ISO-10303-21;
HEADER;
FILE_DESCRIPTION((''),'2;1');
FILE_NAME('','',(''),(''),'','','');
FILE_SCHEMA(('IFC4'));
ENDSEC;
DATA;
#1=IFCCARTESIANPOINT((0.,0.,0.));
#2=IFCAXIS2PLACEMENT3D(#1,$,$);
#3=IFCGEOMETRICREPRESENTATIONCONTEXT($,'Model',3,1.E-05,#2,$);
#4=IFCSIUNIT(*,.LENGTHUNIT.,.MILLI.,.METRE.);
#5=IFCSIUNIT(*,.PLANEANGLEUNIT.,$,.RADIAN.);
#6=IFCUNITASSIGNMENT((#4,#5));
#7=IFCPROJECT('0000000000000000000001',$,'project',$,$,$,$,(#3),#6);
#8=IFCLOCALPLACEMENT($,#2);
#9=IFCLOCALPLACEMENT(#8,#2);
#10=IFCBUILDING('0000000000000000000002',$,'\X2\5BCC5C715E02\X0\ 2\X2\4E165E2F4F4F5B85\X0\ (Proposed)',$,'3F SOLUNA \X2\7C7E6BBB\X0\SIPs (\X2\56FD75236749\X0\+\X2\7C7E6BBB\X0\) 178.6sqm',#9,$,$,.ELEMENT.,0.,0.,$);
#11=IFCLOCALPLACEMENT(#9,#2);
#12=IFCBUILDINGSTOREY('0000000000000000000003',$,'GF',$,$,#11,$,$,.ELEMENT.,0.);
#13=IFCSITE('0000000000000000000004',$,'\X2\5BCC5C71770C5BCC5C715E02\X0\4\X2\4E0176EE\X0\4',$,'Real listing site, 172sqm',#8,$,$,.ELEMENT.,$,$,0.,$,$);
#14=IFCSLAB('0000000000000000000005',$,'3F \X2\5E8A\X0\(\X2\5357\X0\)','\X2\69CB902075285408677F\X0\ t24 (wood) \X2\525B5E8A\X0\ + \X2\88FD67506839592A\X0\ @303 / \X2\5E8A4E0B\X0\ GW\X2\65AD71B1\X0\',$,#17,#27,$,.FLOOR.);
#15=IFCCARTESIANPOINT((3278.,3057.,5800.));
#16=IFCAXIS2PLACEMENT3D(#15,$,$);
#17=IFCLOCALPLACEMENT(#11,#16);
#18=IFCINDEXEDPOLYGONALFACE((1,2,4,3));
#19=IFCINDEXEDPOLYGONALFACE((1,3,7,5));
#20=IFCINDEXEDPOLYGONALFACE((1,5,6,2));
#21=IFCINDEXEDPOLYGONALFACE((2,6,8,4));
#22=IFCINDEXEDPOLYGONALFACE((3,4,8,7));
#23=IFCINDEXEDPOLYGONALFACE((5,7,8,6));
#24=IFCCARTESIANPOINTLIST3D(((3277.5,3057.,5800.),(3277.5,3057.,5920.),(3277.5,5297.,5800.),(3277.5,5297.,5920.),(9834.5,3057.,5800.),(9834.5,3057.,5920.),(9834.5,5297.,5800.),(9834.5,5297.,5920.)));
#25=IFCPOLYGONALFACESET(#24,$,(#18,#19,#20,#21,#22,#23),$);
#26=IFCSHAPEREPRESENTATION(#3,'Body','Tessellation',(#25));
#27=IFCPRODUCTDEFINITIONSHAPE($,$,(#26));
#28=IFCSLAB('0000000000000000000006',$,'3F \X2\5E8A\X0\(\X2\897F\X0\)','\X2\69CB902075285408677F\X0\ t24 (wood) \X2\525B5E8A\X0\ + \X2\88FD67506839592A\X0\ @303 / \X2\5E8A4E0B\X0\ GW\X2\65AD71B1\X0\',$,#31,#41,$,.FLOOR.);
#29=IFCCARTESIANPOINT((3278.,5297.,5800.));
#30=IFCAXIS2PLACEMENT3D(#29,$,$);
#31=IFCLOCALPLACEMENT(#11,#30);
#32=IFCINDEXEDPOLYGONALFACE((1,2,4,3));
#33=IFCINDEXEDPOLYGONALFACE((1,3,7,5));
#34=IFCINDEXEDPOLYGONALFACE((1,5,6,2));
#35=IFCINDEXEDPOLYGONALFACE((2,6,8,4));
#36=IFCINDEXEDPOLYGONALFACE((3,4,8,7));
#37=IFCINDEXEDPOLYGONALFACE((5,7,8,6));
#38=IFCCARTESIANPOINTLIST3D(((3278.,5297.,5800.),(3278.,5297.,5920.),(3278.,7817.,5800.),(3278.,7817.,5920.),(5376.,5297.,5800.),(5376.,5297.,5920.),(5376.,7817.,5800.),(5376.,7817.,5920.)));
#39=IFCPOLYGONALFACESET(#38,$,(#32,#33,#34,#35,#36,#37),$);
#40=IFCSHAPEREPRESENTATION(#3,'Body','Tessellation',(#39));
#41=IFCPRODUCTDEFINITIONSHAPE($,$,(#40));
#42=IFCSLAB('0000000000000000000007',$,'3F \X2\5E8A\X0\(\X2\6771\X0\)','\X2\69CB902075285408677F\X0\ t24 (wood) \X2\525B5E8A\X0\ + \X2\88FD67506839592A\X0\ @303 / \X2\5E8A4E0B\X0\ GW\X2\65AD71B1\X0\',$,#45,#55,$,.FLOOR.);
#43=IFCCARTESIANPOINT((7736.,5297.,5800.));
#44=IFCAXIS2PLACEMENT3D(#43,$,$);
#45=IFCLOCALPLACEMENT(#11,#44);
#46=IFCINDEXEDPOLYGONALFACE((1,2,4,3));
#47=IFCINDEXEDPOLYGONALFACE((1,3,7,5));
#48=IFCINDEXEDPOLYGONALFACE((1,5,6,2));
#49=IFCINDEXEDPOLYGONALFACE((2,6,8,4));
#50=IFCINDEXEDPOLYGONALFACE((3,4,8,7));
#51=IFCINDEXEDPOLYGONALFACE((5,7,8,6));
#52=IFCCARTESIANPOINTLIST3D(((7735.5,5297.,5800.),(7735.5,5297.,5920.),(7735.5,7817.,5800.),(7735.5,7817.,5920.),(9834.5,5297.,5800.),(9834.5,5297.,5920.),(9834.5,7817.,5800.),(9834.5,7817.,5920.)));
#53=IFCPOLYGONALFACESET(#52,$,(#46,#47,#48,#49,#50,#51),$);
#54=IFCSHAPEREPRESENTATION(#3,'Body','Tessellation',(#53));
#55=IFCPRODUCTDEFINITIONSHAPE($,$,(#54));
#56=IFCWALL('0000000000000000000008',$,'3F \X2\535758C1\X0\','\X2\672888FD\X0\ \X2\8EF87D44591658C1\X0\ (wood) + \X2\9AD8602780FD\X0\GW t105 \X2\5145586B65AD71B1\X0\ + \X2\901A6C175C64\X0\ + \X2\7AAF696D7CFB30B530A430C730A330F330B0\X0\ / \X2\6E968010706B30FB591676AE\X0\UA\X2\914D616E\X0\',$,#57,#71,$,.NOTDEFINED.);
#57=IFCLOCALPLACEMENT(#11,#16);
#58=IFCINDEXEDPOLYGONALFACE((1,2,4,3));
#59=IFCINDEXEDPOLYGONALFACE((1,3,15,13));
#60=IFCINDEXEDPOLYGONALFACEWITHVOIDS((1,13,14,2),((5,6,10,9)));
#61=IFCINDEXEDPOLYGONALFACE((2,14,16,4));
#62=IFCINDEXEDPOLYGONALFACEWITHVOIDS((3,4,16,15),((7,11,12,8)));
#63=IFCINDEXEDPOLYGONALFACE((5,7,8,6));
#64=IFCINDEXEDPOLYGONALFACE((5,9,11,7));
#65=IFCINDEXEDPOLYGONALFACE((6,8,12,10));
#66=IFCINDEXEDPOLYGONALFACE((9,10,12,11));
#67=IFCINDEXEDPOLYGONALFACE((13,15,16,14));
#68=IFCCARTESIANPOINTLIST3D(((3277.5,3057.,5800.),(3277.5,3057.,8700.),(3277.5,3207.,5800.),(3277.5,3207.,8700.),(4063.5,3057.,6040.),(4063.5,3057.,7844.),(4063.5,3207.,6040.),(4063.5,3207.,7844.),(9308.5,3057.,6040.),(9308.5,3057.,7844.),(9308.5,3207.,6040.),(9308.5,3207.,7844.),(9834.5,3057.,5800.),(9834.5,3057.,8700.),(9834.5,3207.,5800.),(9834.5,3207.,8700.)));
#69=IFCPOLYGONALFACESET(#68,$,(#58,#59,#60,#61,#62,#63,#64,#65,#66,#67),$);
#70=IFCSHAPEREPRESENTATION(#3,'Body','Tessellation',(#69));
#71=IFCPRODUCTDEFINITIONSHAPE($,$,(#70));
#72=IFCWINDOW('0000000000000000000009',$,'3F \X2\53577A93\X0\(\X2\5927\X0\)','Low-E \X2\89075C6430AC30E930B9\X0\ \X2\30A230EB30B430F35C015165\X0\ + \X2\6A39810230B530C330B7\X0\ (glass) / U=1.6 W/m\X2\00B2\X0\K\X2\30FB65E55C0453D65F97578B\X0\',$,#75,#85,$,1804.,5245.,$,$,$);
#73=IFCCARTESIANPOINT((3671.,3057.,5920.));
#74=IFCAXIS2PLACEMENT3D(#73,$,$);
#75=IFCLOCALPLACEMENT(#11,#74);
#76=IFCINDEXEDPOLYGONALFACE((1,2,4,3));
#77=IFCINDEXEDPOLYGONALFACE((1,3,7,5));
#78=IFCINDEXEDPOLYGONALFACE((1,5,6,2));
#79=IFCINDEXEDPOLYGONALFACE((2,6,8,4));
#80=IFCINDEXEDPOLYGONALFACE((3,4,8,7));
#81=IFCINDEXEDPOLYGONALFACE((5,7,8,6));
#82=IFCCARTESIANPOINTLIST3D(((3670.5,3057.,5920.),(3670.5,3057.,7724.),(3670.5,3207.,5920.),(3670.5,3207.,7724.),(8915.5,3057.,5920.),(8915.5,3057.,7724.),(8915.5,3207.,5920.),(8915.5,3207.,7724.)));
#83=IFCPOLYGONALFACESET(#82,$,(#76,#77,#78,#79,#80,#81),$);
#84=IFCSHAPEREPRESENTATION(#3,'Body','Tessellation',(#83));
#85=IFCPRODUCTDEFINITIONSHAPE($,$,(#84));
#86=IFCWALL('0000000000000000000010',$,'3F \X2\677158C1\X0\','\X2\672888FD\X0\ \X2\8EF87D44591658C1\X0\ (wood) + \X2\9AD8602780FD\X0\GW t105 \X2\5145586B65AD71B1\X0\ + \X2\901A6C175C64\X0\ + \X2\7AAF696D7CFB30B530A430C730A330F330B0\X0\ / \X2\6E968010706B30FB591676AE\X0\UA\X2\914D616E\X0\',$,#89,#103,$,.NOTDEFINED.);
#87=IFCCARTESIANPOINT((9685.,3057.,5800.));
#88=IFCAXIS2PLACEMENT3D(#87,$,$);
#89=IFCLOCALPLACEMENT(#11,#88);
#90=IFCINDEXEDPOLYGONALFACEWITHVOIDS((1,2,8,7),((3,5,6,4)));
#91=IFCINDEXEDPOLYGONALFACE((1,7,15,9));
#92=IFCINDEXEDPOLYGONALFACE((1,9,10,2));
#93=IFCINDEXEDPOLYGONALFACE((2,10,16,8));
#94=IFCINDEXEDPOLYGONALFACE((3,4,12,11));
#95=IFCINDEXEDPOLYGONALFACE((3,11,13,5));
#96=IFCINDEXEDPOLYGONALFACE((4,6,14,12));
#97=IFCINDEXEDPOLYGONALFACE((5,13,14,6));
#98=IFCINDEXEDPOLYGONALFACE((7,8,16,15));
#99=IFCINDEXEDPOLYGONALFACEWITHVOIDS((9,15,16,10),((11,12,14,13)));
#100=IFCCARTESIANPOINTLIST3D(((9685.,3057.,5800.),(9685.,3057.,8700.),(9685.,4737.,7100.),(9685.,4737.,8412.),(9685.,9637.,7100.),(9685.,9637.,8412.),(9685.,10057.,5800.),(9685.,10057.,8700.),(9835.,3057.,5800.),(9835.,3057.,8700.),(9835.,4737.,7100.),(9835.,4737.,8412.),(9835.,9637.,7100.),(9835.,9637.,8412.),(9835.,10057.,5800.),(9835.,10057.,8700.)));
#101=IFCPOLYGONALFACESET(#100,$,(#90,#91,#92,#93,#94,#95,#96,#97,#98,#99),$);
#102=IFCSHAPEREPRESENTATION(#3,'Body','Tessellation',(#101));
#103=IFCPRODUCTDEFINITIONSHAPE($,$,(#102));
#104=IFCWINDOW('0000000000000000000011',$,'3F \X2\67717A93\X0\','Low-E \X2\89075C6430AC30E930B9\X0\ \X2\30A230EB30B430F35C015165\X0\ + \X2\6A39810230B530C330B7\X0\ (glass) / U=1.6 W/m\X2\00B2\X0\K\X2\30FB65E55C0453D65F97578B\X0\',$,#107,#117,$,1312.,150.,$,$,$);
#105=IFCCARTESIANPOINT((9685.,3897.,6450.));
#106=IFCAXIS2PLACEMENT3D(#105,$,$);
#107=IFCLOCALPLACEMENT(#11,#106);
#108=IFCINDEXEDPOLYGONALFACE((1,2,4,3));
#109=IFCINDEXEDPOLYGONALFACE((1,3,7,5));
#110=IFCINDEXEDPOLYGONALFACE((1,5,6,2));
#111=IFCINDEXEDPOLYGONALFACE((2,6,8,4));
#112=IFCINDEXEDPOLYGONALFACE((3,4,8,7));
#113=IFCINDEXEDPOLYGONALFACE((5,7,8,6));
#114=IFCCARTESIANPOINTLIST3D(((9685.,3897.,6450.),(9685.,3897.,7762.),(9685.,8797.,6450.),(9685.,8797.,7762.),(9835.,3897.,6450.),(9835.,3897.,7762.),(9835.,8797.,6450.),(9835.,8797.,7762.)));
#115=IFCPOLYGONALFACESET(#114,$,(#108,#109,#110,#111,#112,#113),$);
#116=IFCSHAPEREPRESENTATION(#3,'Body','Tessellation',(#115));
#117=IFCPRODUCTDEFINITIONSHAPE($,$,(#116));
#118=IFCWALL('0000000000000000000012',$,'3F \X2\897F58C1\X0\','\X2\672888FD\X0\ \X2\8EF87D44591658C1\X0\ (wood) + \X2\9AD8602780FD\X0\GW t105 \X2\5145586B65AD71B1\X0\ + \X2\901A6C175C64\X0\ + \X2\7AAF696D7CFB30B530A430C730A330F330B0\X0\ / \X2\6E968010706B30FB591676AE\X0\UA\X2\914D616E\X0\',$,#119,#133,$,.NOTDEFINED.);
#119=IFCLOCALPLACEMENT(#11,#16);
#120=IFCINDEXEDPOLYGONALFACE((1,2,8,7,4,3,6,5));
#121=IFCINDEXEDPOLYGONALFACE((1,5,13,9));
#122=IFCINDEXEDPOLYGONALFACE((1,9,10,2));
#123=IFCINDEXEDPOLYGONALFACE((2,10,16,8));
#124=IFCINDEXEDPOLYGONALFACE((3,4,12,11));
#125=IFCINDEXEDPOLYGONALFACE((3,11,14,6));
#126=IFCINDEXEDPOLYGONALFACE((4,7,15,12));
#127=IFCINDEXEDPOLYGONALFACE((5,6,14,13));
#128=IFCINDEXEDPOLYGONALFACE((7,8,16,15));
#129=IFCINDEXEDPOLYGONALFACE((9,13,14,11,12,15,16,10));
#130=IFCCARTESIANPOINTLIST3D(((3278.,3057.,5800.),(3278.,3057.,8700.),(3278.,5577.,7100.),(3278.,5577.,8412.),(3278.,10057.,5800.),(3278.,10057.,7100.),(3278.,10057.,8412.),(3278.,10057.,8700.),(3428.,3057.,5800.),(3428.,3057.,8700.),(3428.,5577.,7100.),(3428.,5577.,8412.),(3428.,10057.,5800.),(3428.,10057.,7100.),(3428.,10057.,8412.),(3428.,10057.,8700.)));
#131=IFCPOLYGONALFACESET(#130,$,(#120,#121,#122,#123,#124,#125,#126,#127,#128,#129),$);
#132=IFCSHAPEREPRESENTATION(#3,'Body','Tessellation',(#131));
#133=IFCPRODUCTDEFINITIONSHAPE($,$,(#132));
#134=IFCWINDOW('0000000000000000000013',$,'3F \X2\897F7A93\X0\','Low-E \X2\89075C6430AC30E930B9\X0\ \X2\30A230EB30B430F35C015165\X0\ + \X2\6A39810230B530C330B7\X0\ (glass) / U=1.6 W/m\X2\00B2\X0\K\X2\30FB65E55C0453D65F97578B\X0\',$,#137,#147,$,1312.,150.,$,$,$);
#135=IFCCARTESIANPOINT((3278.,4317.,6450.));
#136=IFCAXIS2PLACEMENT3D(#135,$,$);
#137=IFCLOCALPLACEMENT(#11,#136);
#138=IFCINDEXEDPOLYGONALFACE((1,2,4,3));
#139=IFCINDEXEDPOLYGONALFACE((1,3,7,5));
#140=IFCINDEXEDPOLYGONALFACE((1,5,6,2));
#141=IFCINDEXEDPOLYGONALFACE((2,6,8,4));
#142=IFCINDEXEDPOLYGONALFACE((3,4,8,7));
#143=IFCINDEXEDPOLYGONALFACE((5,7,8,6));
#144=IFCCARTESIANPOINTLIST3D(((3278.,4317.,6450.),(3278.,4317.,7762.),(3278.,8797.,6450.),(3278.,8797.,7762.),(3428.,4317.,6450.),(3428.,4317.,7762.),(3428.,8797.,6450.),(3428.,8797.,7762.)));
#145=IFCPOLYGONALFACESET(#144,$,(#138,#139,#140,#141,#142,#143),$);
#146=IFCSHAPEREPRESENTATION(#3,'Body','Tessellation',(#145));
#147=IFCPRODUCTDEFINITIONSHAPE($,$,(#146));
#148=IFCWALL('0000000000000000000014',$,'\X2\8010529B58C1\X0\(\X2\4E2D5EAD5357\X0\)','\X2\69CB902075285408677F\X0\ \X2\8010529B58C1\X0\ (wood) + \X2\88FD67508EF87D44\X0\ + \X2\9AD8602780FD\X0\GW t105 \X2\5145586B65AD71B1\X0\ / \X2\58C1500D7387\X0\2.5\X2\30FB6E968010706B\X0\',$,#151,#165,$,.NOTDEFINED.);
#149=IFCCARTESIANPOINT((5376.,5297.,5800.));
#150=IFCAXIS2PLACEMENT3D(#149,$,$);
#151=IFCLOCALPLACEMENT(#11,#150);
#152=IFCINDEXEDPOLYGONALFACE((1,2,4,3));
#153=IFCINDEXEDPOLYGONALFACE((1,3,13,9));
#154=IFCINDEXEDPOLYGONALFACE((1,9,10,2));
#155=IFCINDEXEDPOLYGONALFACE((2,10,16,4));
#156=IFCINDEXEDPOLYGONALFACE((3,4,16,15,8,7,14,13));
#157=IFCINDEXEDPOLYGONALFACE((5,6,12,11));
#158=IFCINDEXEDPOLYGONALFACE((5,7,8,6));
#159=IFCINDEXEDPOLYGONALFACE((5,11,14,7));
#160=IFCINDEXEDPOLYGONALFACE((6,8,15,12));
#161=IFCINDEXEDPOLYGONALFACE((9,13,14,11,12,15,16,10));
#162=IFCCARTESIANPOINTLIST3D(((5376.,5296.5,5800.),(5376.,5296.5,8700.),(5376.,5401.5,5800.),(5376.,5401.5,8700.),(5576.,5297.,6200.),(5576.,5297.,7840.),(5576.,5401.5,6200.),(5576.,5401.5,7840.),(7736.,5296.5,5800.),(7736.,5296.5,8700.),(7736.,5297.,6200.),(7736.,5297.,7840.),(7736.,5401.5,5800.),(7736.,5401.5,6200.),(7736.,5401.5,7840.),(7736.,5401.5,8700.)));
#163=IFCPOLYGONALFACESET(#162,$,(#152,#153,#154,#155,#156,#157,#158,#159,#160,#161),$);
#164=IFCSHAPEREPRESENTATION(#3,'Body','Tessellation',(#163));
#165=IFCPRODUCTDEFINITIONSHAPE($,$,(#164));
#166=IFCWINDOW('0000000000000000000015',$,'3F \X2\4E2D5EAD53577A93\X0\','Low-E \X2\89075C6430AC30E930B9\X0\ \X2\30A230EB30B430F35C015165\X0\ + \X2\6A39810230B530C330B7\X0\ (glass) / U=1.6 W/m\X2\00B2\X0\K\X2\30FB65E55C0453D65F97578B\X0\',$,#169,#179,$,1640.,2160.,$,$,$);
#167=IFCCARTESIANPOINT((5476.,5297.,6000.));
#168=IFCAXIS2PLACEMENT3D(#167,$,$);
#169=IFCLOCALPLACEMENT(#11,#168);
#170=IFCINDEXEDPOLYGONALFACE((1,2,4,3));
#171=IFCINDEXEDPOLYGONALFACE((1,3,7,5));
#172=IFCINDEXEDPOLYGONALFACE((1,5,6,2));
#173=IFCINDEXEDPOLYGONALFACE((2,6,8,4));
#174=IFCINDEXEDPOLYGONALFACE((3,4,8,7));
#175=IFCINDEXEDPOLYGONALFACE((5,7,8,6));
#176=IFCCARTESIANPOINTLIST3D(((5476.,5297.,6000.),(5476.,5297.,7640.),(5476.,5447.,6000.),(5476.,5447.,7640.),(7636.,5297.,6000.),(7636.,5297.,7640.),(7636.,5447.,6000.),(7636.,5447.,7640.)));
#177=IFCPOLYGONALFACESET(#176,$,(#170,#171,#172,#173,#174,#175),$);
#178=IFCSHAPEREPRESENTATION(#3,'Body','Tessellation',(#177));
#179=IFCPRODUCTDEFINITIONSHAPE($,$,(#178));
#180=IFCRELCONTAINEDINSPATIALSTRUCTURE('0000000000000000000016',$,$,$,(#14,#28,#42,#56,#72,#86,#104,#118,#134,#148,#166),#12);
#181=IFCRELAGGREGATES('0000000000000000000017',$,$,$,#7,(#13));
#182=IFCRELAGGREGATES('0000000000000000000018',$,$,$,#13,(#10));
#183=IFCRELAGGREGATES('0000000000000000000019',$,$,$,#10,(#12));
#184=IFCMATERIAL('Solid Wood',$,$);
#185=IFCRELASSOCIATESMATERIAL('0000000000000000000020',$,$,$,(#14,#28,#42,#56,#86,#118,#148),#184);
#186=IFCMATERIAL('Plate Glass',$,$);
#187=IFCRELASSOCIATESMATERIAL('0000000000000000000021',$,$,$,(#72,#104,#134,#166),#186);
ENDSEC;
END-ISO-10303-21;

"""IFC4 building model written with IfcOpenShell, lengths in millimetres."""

from ifc_helpers import new_model, si_unit, frame, frame_2d, origin, place, context, project, spatial, rectangle, extrude, material, element, fill, save


model = new_model("IFC4")

# Units and contexts
model_context = context("Model", 3, precision=1e-05, world=origin())
ifc_project = project(units=[si_unit("LENGTHUNIT", "METRE", prefix="MILLI"), si_unit("PLANEANGLEUNIT", "RADIAN")], contexts=[model_context])

# Site, building, storey
site_placement = place(None, origin())
site = spatial("IfcSite", under=ifc_project, at=site_placement, Name="富山県富山市4丁目4", ObjectType="Real listing site, 172sqm", CompositionType="ELEMENT", RefElevation=0.0)
building_placement = place(site_placement, origin())
building = spatial("IfcBuilding", under=site, at=building_placement, Name="富山市 2世帯住宅 (Proposed)", ObjectType="3F SOLUNA 籾殻SIPs (国産杉+籾殻) 178.6sqm", CompositionType="ELEMENT", ElevationOfRefHeight=0.0, ElevationOfTerrain=0.0)
storey_placement = place(building_placement, origin())
storey = spatial("IfcBuildingStorey", under=building, at=storey_placement, Name="GF", CompositionType="ELEMENT", Elevation=0.0)

# Slabs
ifc_material_1 = material(Name="Solid Wood")
slab_1_placement = place(storey_placement, frame((3278.0, 3057.0, 5800.0)))
element("IfcSlab", 1, at=slab_1_placement, inside=storey, material=ifc_material_1, Name="3F 床(南)", Description="構造用合板 t24 (wood) 剛床 + 製材根太 @303 / 床下 GW断熱", PredefinedType="FLOOR", context=model_context, shape_type="SweptSolid", body=[
    extrude(rectangle(XDim=6557.0, YDim=2240.0, at=frame_2d((3278.0, 1120.0))), frame((3278.0, 3057.0, 5800.0)), (0.0, 0.0, 1.0), 120.0),
])
slab_2_placement = place(storey_placement, frame((3278.0, 5297.0, 5800.0)))
element("IfcSlab", 2, at=slab_2_placement, inside=storey, material=ifc_material_1, Name="3F 床(西)", Description="構造用合板 t24 (wood) 剛床 + 製材根太 @303 / 床下 GW断熱", PredefinedType="FLOOR", context=model_context, shape_type="SweptSolid", body=[
    extrude(rectangle(XDim=2098.0, YDim=2520.0, at=frame_2d((1049.0, 1260.0))), frame((3278.0, 5297.0, 5800.0)), (0.0, 0.0, 1.0), 120.0),
])
slab_3_placement = place(storey_placement, frame((7736.0, 5297.0, 5800.0)))
element("IfcSlab", 3, at=slab_3_placement, inside=storey, material=ifc_material_1, Name="3F 床(東)", Description="構造用合板 t24 (wood) 剛床 + 製材根太 @303 / 床下 GW断熱", PredefinedType="FLOOR", context=model_context, shape_type="SweptSolid", body=[
    extrude(rectangle(XDim=2099.0, YDim=2520.0, at=frame_2d((1049.0, 1260.0))), frame((7736.0, 5297.0, 5800.0)), (0.0, 0.0, 1.0), 120.0),
])

# Walls, openings, windows
wall_1_placement = place(storey_placement, frame((3278.0, 3057.0, 5800.0)))
wall_1 = element("IfcWall", 4, at=wall_1_placement, inside=storey, material=ifc_material_1, Name="3F 南壁", Description="木製 軸組外壁 (wood) + 高性能GW t105 充填断熱 + 通気層 + 窯業系サイディング / 準耐火・外皮UA配慮", PredefinedType="NOTDEFINED", context=model_context, shape_type="SweptSolid", body=[
    extrude(rectangle(XDim=6557.0, YDim=150.0, at=frame_2d((3278.0, 75.0))), frame((3278.0, 3057.0, 5800.0)), (0.0, 0.0, 1.0), 2900.0),
])
opening_1_placement = place(storey_placement, frame((3671.0, 3057.0, 5920.0)))
opening_1 = element("IfcOpeningElement", 5, at=opening_1_placement, cuts=wall_1, PredefinedType="NOTDEFINED", context=model_context, shape_type="SweptSolid", body=[
    extrude(rectangle(XDim=5245.0, YDim=150.0, at=frame_2d((2622.0, 75.0))), frame((3671.0, 3057.0, 5920.0)), (0.0, 0.0, 1.0), 1804.0),
])
ifc_material_2 = material(Name="Plate Glass")
window_1_placement = place(storey_placement, frame((3671.0, 3057.0, 5920.0)))
window_1 = element("IfcWindow", 6, at=window_1_placement, inside=storey, material=ifc_material_2, Name="3F 南窓(大)", Description="Low-E 複層ガラス アルゴン封入 + 樹脂サッシ (glass) / U=1.6 W/m²K・日射取得型", OverallHeight=1804.0, OverallWidth=5245.0, context=model_context, shape_type="SweptSolid", body=[
    extrude(rectangle(XDim=5245.0, YDim=150.0, at=frame_2d((2622.0, 75.0))), frame((3671.0, 3057.0, 5920.0)), (0.0, 0.0, 1.0), 1804.0),
])
fill(opening_1, window_1)
wall_2_placement = place(storey_placement, frame((9685.0, 3057.0, 5800.0)))
wall_2 = element("IfcWall", 7, at=wall_2_placement, inside=storey, material=ifc_material_1, Name="3F 東壁", Description="木製 軸組外壁 (wood) + 高性能GW t105 充填断熱 + 通気層 + 窯業系サイディング / 準耐火・外皮UA配慮", PredefinedType="NOTDEFINED", context=model_context, shape_type="SweptSolid", body=[
    extrude(rectangle(XDim=150.0, YDim=7000.0, at=frame_2d((75.0, 3500.0))), frame((9685.0, 3057.0, 5800.0)), (0.0, 0.0, 1.0), 2900.0),
])
opening_2_placement = place(storey_placement, frame((9685.0, 3897.0, 6450.0)))
opening_2 = element("IfcOpeningElement", 8, at=opening_2_placement, cuts=wall_2, PredefinedType="NOTDEFINED", context=model_context, shape_type="SweptSolid", body=[
    extrude(rectangle(XDim=150.0, YDim=4900.0, at=frame_2d((75.0, 2450.0))), frame((9685.0, 3897.0, 6450.0)), (0.0, 0.0, 1.0), 1312.0),
])
window_2_placement = place(storey_placement, frame((9685.0, 3897.0, 6450.0)))
window_2 = element("IfcWindow", 9, at=window_2_placement, inside=storey, material=ifc_material_2, Name="3F 東窓", Description="Low-E 複層ガラス アルゴン封入 + 樹脂サッシ (glass) / U=1.6 W/m²K・日射取得型", OverallHeight=1312.0, OverallWidth=150.0, context=model_context, shape_type="SweptSolid", body=[
    extrude(rectangle(XDim=150.0, YDim=4900.0, at=frame_2d((75.0, 2450.0))), frame((9685.0, 3897.0, 6450.0)), (0.0, 0.0, 1.0), 1312.0),
])
fill(opening_2, window_2)
wall_3_placement = place(storey_placement, frame((3278.0, 3057.0, 5800.0)))
wall_3 = element("IfcWall", 10, at=wall_3_placement, inside=storey, material=ifc_material_1, Name="3F 西壁", Description="木製 軸組外壁 (wood) + 高性能GW t105 充填断熱 + 通気層 + 窯業系サイディング / 準耐火・外皮UA配慮", PredefinedType="NOTDEFINED", context=model_context, shape_type="SweptSolid", body=[
    extrude(rectangle(XDim=150.0, YDim=7000.0, at=frame_2d((75.0, 3500.0))), frame((3278.0, 3057.0, 5800.0)), (0.0, 0.0, 1.0), 2900.0),
])
opening_3_placement = place(storey_placement, frame((3278.0, 4317.0, 6450.0)))
opening_3 = element("IfcOpeningElement", 11, at=opening_3_placement, cuts=wall_3, PredefinedType="NOTDEFINED", context=model_context, shape_type="SweptSolid", body=[
    extrude(rectangle(XDim=150.0, YDim=4480.0, at=frame_2d((75.0, 2240.0))), frame((3278.0, 4317.0, 6450.0)), (0.0, 0.0, 1.0), 1312.0),
])
window_3_placement = place(storey_placement, frame((3278.0, 4317.0, 6450.0)))
window_3 = element("IfcWindow", 12, at=window_3_placement, inside=storey, material=ifc_material_2, Name="3F 西窓", Description="Low-E 複層ガラス アルゴン封入 + 樹脂サッシ (glass) / U=1.6 W/m²K・日射取得型", OverallHeight=1312.0, OverallWidth=150.0, context=model_context, shape_type="SweptSolid", body=[
    extrude(rectangle(XDim=150.0, YDim=4480.0, at=frame_2d((75.0, 2240.0))), frame((3278.0, 4317.0, 6450.0)), (0.0, 0.0, 1.0), 1312.0),
])
fill(opening_3, window_3)
wall_4_placement = place(storey_placement, frame((5376.0, 5297.0, 5800.0)))
wall_4 = element("IfcWall", 13, at=wall_4_placement, inside=storey, material=ifc_material_1, Name="耐力壁(中庭南)", Description="構造用合板 耐力壁 (wood) + 製材軸組 + 高性能GW t105 充填断熱 / 壁倍率2.5・準耐火", PredefinedType="NOTDEFINED", context=model_context, shape_type="SweptSolid", body=[
    extrude(rectangle(XDim=2360.0, YDim=105.0, at=frame_2d((1180.0, 52.0))), frame((5376.0, 5297.0, 5800.0)), (0.0, 0.0, 1.0), 2900.0),
])
opening_4_placement = place(storey_placement, frame((5476.0, 5297.0, 6000.0)))
opening_4 = element("IfcOpeningElement", 14, at=opening_4_placement, cuts=wall_4, PredefinedType="NOTDEFINED", context=model_context, shape_type="SweptSolid", body=[
    extrude(rectangle(XDim=2160.0, YDim=150.0, at=frame_2d((1080.0, 75.0))), frame((5476.0, 5297.0, 6000.0)), (0.0, 0.0, 1.0), 1640.0),
])
window_4_placement = place(storey_placement, frame((5476.0, 5297.0, 6000.0)))
window_4 = element("IfcWindow", 15, at=window_4_placement, inside=storey, material=ifc_material_2, Name="3F 中庭南窓", Description="Low-E 複層ガラス アルゴン封入 + 樹脂サッシ (glass) / U=1.6 W/m²K・日射取得型", OverallHeight=1640.0, OverallWidth=2160.0, context=model_context, shape_type="SweptSolid", body=[
    extrude(rectangle(XDim=2160.0, YDim=150.0, at=frame_2d((1080.0, 75.0))), frame((5476.0, 5297.0, 6000.0)), (0.0, 0.0, 1.0), 1640.0),
])
fill(opening_4, window_4)

save(model, "model.ifc")
